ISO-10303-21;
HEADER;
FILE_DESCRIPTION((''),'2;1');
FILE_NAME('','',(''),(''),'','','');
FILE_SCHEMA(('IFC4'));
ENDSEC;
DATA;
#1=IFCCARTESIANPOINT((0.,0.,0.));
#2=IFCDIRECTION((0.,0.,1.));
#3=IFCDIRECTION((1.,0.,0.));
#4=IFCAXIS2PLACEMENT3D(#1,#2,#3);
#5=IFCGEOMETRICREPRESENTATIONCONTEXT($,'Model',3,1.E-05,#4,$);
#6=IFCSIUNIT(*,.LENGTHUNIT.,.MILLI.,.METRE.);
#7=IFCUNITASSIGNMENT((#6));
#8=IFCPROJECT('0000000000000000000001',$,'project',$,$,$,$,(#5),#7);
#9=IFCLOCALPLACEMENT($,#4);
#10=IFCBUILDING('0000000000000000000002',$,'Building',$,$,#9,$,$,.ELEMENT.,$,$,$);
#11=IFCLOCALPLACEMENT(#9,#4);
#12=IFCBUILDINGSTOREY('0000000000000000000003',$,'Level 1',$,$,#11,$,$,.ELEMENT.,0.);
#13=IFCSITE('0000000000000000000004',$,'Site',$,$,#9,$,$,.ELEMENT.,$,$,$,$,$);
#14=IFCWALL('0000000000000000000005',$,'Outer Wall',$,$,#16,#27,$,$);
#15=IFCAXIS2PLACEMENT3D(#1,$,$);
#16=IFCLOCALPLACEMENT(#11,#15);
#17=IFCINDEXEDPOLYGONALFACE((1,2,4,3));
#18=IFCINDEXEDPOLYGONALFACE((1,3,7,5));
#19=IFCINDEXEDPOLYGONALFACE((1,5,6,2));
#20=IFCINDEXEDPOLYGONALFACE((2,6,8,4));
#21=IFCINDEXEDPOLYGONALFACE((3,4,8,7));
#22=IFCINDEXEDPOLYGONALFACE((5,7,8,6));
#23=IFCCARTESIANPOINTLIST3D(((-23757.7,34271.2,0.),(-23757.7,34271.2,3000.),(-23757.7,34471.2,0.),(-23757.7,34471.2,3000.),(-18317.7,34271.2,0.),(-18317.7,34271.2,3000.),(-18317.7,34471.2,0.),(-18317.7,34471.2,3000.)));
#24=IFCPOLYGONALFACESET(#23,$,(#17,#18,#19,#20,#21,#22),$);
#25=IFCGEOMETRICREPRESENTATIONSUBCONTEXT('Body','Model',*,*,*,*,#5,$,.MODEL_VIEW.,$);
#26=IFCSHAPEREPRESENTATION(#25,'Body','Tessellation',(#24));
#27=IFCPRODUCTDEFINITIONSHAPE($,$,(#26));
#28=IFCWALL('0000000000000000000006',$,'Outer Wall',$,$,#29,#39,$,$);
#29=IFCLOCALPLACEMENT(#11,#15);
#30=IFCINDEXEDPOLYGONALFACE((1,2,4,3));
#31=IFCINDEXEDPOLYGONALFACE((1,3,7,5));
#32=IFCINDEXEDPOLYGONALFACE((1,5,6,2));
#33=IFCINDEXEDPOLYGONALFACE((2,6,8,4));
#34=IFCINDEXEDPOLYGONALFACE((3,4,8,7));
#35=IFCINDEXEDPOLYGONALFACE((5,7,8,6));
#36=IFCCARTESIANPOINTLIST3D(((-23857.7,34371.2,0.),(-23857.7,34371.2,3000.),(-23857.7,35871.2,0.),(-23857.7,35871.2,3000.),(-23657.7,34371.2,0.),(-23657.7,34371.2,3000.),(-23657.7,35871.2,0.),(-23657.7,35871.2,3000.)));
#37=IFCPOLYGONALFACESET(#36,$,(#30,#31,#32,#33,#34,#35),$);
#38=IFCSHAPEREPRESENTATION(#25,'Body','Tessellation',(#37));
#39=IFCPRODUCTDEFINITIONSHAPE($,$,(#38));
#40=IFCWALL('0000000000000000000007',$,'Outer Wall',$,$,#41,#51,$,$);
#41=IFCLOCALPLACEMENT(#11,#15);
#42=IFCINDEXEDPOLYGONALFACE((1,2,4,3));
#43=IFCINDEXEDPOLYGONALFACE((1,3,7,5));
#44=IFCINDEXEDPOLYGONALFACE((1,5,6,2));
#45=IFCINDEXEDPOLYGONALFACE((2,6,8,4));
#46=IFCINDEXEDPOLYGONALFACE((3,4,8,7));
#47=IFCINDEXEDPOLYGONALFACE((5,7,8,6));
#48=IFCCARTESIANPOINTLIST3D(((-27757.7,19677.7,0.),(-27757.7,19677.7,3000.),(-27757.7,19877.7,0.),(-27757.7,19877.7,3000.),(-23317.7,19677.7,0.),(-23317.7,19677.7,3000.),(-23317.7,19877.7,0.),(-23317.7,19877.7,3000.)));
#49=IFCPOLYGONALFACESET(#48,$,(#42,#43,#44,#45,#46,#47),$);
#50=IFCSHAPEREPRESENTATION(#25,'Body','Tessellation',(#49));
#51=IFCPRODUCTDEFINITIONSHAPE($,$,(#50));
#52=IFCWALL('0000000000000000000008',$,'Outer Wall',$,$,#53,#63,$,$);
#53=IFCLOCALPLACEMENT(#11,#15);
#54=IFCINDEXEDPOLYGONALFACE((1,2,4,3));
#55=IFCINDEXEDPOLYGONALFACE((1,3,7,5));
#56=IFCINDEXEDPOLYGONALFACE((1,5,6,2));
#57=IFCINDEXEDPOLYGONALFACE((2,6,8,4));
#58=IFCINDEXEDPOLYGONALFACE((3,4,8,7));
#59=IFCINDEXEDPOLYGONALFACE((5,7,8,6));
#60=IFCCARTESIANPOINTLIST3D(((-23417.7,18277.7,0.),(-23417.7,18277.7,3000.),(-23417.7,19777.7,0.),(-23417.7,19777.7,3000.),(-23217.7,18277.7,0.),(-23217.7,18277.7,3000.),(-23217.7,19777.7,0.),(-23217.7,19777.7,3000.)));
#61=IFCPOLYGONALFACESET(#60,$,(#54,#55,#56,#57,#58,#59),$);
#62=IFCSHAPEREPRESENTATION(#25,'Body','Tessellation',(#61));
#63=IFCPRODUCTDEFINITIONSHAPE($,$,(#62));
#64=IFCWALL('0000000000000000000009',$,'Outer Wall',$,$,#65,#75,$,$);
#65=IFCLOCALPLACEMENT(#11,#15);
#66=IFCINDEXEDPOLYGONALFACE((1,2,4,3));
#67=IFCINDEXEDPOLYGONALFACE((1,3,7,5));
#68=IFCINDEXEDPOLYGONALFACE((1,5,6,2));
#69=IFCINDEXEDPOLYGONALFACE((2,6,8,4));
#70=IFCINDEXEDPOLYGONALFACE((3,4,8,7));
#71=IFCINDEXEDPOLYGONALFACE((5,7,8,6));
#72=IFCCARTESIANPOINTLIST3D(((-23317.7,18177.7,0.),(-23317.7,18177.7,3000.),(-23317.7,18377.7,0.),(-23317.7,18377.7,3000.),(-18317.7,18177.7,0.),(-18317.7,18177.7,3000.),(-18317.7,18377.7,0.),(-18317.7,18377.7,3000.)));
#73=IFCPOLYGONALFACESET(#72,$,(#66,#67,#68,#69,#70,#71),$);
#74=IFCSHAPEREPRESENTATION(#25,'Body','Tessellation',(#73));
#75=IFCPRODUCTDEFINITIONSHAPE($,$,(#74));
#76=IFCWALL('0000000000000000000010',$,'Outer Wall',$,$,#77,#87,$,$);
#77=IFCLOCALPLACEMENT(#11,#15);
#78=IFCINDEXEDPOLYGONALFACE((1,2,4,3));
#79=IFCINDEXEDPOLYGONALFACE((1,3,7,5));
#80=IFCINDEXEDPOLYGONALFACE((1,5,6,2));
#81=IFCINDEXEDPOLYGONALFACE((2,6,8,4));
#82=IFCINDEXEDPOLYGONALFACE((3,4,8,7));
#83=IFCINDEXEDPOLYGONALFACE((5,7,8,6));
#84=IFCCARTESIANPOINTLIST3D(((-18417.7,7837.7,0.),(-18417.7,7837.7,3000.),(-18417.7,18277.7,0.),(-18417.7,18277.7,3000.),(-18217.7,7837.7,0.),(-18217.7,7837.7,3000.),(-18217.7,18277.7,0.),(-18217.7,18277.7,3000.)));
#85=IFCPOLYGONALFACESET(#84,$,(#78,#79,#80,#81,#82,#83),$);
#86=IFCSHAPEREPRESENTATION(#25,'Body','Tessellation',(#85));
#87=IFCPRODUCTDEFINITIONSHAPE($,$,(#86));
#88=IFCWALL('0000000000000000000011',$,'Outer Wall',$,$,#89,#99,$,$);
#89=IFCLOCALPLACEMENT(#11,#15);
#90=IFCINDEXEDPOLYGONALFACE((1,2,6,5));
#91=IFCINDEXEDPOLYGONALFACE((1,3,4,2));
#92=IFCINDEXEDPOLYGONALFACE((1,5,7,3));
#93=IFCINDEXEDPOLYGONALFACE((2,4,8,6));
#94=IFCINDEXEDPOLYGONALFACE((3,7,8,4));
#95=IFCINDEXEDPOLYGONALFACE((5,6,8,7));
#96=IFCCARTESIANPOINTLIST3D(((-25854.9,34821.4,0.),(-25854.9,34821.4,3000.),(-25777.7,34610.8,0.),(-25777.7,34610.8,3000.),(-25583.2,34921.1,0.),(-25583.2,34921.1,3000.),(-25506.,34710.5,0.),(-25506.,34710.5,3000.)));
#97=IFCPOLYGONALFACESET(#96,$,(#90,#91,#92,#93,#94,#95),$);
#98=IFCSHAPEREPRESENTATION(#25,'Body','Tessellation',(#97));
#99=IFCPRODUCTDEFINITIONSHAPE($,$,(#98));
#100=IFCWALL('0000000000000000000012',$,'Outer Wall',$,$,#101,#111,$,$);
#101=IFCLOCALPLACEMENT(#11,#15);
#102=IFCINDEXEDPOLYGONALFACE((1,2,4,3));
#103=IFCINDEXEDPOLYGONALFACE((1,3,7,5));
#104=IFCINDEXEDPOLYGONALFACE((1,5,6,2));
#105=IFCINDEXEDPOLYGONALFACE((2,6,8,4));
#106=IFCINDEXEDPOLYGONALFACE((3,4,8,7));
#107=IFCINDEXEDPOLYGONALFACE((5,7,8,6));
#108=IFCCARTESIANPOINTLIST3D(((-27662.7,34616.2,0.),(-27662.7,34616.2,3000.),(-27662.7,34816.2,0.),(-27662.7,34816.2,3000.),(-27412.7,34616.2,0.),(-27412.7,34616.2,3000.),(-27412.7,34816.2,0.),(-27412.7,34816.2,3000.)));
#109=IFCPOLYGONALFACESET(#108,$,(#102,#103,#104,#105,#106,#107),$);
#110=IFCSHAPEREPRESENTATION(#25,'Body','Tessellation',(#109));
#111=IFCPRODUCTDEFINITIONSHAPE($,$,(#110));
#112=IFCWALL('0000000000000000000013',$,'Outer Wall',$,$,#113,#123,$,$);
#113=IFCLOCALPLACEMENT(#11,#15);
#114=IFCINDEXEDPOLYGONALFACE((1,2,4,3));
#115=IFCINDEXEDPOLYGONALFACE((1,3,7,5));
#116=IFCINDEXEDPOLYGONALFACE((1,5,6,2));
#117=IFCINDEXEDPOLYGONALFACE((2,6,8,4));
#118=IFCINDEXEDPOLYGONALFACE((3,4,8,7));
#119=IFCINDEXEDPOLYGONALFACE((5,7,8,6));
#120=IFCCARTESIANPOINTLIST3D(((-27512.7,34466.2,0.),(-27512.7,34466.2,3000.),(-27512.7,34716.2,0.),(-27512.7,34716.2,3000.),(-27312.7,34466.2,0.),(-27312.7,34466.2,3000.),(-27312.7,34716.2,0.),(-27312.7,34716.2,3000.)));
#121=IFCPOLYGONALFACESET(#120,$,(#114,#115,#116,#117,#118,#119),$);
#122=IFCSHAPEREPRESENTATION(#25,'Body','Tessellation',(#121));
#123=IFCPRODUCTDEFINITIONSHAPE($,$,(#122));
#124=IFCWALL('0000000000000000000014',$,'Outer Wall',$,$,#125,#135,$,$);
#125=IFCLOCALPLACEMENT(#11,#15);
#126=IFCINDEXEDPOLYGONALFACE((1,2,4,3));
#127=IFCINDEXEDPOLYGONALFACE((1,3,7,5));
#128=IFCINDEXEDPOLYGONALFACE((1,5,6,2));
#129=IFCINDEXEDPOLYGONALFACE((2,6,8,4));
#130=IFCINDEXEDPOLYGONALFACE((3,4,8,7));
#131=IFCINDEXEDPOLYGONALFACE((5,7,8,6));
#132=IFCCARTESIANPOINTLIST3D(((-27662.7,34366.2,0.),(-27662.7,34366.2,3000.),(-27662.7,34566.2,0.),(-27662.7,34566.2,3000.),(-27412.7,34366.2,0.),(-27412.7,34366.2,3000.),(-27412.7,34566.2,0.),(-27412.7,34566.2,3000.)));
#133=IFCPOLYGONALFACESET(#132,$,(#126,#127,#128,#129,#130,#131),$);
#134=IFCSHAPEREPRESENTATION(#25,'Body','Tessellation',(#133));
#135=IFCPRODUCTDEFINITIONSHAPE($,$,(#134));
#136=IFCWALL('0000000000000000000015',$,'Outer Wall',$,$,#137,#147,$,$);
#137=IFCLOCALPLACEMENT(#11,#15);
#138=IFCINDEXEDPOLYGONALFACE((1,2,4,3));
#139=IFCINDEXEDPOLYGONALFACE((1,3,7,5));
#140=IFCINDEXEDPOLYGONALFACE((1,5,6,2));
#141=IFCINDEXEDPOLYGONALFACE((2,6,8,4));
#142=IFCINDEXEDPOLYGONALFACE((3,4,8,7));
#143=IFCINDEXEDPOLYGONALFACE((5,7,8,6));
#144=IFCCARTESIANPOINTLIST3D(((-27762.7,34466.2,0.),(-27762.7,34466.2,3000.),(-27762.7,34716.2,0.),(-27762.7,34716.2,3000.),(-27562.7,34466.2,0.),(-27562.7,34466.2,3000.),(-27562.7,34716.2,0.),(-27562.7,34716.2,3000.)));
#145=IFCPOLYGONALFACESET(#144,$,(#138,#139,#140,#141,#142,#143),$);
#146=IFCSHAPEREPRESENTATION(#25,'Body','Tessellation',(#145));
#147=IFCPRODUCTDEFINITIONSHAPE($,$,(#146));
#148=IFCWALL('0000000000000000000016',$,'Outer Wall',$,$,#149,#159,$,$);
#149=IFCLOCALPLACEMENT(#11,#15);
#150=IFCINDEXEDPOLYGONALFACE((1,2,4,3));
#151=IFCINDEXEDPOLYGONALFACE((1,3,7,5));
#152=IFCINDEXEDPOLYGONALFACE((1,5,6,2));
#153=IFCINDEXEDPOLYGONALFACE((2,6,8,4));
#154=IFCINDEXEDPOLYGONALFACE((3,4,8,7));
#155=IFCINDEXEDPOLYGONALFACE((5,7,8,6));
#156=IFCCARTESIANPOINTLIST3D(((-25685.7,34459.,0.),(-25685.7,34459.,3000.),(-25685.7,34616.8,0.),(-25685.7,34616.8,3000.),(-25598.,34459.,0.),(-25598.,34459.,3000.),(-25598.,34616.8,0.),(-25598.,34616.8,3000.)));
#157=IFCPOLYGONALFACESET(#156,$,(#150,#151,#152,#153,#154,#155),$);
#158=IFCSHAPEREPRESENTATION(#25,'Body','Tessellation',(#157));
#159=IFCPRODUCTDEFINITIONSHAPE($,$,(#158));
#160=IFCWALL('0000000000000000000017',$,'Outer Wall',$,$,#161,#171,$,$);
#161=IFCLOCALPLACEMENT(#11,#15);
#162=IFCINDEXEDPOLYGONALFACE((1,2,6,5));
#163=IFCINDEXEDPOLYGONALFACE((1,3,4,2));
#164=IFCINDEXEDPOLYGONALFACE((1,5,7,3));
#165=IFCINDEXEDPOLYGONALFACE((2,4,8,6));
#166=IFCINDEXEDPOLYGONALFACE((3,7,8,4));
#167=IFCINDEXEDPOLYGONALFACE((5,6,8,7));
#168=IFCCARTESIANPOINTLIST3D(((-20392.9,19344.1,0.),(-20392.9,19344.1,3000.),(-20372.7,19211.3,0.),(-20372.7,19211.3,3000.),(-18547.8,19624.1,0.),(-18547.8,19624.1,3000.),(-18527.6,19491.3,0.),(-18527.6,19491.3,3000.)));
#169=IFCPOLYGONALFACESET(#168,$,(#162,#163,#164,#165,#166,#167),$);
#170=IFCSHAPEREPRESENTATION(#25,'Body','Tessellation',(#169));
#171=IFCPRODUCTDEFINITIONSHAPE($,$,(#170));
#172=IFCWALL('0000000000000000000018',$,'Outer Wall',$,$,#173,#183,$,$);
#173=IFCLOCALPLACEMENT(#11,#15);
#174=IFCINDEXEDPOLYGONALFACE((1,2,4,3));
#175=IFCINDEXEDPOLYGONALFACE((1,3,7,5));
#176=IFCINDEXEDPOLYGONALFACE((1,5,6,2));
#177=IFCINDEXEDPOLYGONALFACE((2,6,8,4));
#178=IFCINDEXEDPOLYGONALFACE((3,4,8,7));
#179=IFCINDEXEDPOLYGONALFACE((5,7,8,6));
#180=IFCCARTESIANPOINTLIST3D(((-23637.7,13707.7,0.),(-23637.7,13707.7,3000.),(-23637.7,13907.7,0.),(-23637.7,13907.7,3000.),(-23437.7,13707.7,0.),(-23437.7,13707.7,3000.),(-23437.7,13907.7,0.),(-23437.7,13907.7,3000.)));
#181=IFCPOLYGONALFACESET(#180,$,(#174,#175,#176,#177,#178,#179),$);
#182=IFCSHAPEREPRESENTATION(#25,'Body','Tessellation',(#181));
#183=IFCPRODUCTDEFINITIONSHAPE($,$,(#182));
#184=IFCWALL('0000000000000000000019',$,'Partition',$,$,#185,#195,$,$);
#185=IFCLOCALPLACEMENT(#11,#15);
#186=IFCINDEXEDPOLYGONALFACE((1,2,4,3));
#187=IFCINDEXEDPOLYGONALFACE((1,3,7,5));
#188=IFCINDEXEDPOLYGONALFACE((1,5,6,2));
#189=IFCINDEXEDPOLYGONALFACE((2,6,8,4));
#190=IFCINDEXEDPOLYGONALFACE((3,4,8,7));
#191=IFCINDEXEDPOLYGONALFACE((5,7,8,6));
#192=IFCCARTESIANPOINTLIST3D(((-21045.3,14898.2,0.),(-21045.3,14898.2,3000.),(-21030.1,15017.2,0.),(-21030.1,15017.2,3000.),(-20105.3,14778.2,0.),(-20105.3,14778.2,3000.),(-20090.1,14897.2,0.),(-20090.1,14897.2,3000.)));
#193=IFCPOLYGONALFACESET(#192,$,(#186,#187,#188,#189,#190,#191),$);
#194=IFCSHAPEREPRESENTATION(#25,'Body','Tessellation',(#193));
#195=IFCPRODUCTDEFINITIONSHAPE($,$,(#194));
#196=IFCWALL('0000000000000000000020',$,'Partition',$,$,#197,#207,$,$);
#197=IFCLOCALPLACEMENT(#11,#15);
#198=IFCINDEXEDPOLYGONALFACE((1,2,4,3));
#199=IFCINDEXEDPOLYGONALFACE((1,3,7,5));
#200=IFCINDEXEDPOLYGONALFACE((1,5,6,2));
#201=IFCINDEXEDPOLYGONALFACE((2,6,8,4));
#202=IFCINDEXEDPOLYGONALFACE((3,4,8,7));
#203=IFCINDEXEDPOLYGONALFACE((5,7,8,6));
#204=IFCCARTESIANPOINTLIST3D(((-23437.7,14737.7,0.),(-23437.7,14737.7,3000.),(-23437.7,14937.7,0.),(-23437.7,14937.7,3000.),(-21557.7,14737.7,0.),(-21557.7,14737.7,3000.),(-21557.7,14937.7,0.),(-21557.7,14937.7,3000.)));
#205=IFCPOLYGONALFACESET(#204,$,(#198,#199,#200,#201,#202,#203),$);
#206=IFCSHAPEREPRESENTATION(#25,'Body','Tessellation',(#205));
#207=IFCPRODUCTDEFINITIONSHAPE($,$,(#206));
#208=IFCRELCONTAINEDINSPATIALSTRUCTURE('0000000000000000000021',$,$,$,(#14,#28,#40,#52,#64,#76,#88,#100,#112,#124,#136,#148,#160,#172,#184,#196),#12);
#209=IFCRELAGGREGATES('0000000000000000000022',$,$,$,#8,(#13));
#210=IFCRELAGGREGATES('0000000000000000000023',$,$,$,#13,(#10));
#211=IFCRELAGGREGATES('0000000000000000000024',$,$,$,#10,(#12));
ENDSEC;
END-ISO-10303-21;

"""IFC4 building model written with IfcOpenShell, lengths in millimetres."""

from ifc_helpers import new_model, si_unit, frame, frame_2d, origin_with_axes, place, context, subcontext, project, spatial, rectangle, extrude, element, save


model = new_model("IFC4")

# Units and contexts
model_context = context("Model", 3, precision=1e-05, world=origin_with_axes())
body_context = subcontext(model_context, "Body", "Model", "MODEL_VIEW")
ifc_project = project(units=[si_unit("LENGTHUNIT", "METRE", prefix="MILLI")], contexts=[model_context])

# Site, building, storey
placement = place(None, origin_with_axes())
site = spatial("IfcSite", under=ifc_project, at=placement, Name="Site", CompositionType="ELEMENT")
building = spatial("IfcBuilding", under=site, at=placement, Name="Building", CompositionType="ELEMENT")
storey_placement = place(placement, origin_with_axes())
storey = spatial("IfcBuildingStorey", under=building, at=storey_placement, Name="Level 1", CompositionType="ELEMENT", Elevation=0.0)

# Walls
wall_1_placement = place(placement, frame((-18317.7, 34371.2, 0.0), z_axis=(0.0, 0.0, 1.0), x_axis=(-1.0, 0.0, 0.0)))
element("IfcWall", 1, at=wall_1_placement, inside=storey, Name="Outer Wall", context=body_context, shape_type="SweptSolid", body=[
    extrude(rectangle(XDim=5440.0, YDim=200.0, at=frame_2d((2720.0, 0.0), x_axis=(1.0, 0.0))), origin_with_axes(), (0.0, 0.0, 1.0), 3000.0),
])
wall_2_placement = place(placement, frame((-23757.7, 34371.2, 0.0), z_axis=(0.0, 0.0, 1.0), x_axis=(0.0, 1.0, 0.0)))
element("IfcWall", 2, at=wall_2_placement, inside=storey, Name="Outer Wall", context=body_context, shape_type="SweptSolid", body=[
    extrude(rectangle(XDim=1500.0, YDim=200.0, at=frame_2d((750.0, 0.0), x_axis=(1.0, 0.0))), origin_with_axes(), (0.0, 0.0, 1.0), 3000.0),
])
wall_3_placement = place(placement, frame((-27757.7, 19777.7, 0.0), z_axis=(0.0, 0.0, 1.0), x_axis=(1.0, 0.0, 0.0)))
element("IfcWall", 3, at=wall_3_placement, inside=storey, Name="Outer Wall", context=body_context, shape_type="SweptSolid", body=[
    extrude(rectangle(XDim=4440.0, YDim=200.0, at=frame_2d((2220.0, 0.0), x_axis=(1.0, 0.0))), origin_with_axes(), (0.0, 0.0, 1.0), 3000.0),
])
wall_4_placement = place(placement, frame((-23317.7, 19777.7, 0.0), z_axis=(0.0, 0.0, 1.0), x_axis=(0.0, -1.0, 0.0)))
element("IfcWall", 4, at=wall_4_placement, inside=storey, Name="Outer Wall", context=body_context, shape_type="SweptSolid", body=[
    extrude(rectangle(XDim=1500.0, YDim=200.0, at=frame_2d((750.0, 0.0), x_axis=(1.0, 0.0))), origin_with_axes(), (0.0, 0.0, 1.0), 3000.0),
])
wall_5_placement = place(placement, frame((-23317.7, 18277.7, 0.0), z_axis=(0.0, 0.0, 1.0), x_axis=(1.0, 0.0, 0.0)))
element("IfcWall", 5, at=wall_5_placement, inside=storey, Name="Outer Wall", context=body_context, shape_type="SweptSolid", body=[
    extrude(rectangle(XDim=5000.0, YDim=200.0, at=frame_2d((2500.0, 0.0), x_axis=(1.0, 0.0))), origin_with_axes(), (0.0, 0.0, 1.0), 3000.0),
])
wall_6_placement = place(placement, frame((-18317.7, 18277.7, 0.0), z_axis=(0.0, 0.0, 1.0), x_axis=(0.0, -1.0, 0.0)))
element("IfcWall", 6, at=wall_6_placement, inside=storey, Name="Outer Wall", context=body_context, shape_type="SweptSolid", body=[
    extrude(rectangle(XDim=10440.0, YDim=200.0, at=frame_2d((5220.0, 0.0), x_axis=(1.0, 0.0))), origin_with_axes(), (0.0, 0.0, 1.0), 3000.0),
])
wall_7_placement = place(placement, frame((-25719.1, 34871.2, 0.0), z_axis=(0.0, 0.0, 1.0), x_axis=(0.344265, -0.938873, 0.0)))
element("IfcWall", 7, at=wall_7_placement, inside=storey, Name="Outer Wall", context=body_context, shape_type="SweptSolid", body=[
    extrude(rectangle(XDim=224.3, YDim=289.4, at=frame_2d((112.1, 0.0), x_axis=(1.0, 0.0))), origin_with_axes(), (0.0, 0.0, 1.0), 3000.0),
])
wall_8_placement = place(placement, frame((-27662.7, 34716.2, 0.0), z_axis=(0.0, 0.0, 1.0), x_axis=(1.0, 0.0, 0.0)))
element("IfcWall", 8, at=wall_8_placement, inside=storey, Name="Outer Wall", context=body_context, shape_type="SweptSolid", body=[
    extrude(rectangle(XDim=250.0, YDim=200.0, at=frame_2d((125.0, 0.0), x_axis=(1.0, 0.0))), origin_with_axes(), (0.0, 0.0, 1.0), 3000.0),
])
wall_9_placement = place(placement, frame((-27412.7, 34716.2, 0.0), z_axis=(0.0, 0.0, 1.0), x_axis=(0.0, -1.0, 0.0)))
element("IfcWall", 9, at=wall_9_placement, inside=storey, Name="Outer Wall", context=body_context, shape_type="SweptSolid", body=[
    extrude(rectangle(XDim=250.0, YDim=200.0, at=frame_2d((125.0, 0.0), x_axis=(1.0, 0.0))), origin_with_axes(), (0.0, 0.0, 1.0), 3000.0),
])
wall_10_placement = place(placement, frame((-27412.7, 34466.2, 0.0), z_axis=(0.0, 0.0, 1.0), x_axis=(-1.0, 0.0, 0.0)))
element("IfcWall", 10, at=wall_10_placement, inside=storey, Name="Outer Wall", context=body_context, shape_type="SweptSolid", body=[
    extrude(rectangle(XDim=250.0, YDim=200.0, at=frame_2d((125.0, 0.0), x_axis=(1.0, 0.0))), origin_with_axes(), (0.0, 0.0, 1.0), 3000.0),
])
wall_11_placement = place(placement, frame((-27662.7, 34466.2, 0.0), z_axis=(0.0, 0.0, 1.0), x_axis=(0.0, 1.0, 0.0)))
element("IfcWall", 11, at=wall_11_placement, inside=storey, Name="Outer Wall", context=body_context, shape_type="SweptSolid", body=[
    extrude(rectangle(XDim=250.0, YDim=200.0, at=frame_2d((125.0, 0.0), x_axis=(1.0, 0.0))), origin_with_axes(), (0.0, 0.0, 1.0), 3000.0),
])
wall_12_placement = place(placement, frame((-25641.9, 34616.8, 0.0), z_axis=(0.0, 0.0, 1.0), x_axis=(0.0, -1.0, 0.0)))
element("IfcWall", 12, at=wall_12_placement, inside=storey, Name="Outer Wall", context=body_context, shape_type="SweptSolid", body=[
    extrude(rectangle(XDim=157.8, YDim=87.8, at=frame_2d((78.9, 0.0), x_axis=(1.0, 0.0))), origin_with_axes(), (0.0, 0.0, 1.0), 3000.0),
])
wall_13_placement = place(placement, frame((-20382.8, 19277.7, 0.0), z_axis=(0.0, 0.0, 1.0), x_axis=(0.988681, 0.150036, 0.0)))
element("IfcWall", 13, at=wall_13_placement, inside=storey, Name="Outer Wall", context=body_context, shape_type="SweptSolid", body=[
    extrude(rectangle(XDim=1866.2, YDim=134.4, at=frame_2d((933.1, 0.0), x_axis=(1.0, 0.0))), origin_with_axes(), (0.0, 0.0, 1.0), 3000.0),
])
wall_14_placement = place(placement, frame((-23437.7, 13807.7, 0.0), z_axis=(0.0, 0.0, 1.0), x_axis=(-1.0, 0.0, 0.0)))
element("IfcWall", 14, at=wall_14_placement, inside=storey, Name="Outer Wall", context=body_context, shape_type="SweptSolid", body=[
    extrude(rectangle(XDim=200.0, YDim=200.0, at=frame_2d((100.0, 0.0), x_axis=(1.0, 0.0))), origin_with_axes(), (0.0, 0.0, 1.0), 3000.0),
])
wall_15_placement = place(placement, frame((-21037.7, 14957.7, 0.0), z_axis=(0.0, 0.0, 1.0), x_axis=(0.99195, -0.126632, 0.0)))
element("IfcWall", 15, at=wall_15_placement, inside=storey, Name="Partition", context=body_context, shape_type="SweptSolid", body=[
    extrude(rectangle(XDim=947.6, YDim=120.0, at=frame_2d((473.8, 0.0), x_axis=(1.0, 0.0))), origin_with_axes(), (0.0, 0.0, 1.0), 3000.0),
])
wall_16_placement = place(placement, frame((-21557.7, 14837.7, 0.0), z_axis=(0.0, 0.0, 1.0), x_axis=(-1.0, 0.0, 0.0)))
element("IfcWall", 16, at=wall_16_placement, inside=storey, Name="Partition", context=body_context, shape_type="SweptSolid", body=[
    extrude(rectangle(XDim=1880.0, YDim=200.0, at=frame_2d((940.0, 0.0), x_axis=(1.0, 0.0))), origin_with_axes(), (0.0, 0.0, 1.0), 3000.0),
])

save(model, "model.ifc")
